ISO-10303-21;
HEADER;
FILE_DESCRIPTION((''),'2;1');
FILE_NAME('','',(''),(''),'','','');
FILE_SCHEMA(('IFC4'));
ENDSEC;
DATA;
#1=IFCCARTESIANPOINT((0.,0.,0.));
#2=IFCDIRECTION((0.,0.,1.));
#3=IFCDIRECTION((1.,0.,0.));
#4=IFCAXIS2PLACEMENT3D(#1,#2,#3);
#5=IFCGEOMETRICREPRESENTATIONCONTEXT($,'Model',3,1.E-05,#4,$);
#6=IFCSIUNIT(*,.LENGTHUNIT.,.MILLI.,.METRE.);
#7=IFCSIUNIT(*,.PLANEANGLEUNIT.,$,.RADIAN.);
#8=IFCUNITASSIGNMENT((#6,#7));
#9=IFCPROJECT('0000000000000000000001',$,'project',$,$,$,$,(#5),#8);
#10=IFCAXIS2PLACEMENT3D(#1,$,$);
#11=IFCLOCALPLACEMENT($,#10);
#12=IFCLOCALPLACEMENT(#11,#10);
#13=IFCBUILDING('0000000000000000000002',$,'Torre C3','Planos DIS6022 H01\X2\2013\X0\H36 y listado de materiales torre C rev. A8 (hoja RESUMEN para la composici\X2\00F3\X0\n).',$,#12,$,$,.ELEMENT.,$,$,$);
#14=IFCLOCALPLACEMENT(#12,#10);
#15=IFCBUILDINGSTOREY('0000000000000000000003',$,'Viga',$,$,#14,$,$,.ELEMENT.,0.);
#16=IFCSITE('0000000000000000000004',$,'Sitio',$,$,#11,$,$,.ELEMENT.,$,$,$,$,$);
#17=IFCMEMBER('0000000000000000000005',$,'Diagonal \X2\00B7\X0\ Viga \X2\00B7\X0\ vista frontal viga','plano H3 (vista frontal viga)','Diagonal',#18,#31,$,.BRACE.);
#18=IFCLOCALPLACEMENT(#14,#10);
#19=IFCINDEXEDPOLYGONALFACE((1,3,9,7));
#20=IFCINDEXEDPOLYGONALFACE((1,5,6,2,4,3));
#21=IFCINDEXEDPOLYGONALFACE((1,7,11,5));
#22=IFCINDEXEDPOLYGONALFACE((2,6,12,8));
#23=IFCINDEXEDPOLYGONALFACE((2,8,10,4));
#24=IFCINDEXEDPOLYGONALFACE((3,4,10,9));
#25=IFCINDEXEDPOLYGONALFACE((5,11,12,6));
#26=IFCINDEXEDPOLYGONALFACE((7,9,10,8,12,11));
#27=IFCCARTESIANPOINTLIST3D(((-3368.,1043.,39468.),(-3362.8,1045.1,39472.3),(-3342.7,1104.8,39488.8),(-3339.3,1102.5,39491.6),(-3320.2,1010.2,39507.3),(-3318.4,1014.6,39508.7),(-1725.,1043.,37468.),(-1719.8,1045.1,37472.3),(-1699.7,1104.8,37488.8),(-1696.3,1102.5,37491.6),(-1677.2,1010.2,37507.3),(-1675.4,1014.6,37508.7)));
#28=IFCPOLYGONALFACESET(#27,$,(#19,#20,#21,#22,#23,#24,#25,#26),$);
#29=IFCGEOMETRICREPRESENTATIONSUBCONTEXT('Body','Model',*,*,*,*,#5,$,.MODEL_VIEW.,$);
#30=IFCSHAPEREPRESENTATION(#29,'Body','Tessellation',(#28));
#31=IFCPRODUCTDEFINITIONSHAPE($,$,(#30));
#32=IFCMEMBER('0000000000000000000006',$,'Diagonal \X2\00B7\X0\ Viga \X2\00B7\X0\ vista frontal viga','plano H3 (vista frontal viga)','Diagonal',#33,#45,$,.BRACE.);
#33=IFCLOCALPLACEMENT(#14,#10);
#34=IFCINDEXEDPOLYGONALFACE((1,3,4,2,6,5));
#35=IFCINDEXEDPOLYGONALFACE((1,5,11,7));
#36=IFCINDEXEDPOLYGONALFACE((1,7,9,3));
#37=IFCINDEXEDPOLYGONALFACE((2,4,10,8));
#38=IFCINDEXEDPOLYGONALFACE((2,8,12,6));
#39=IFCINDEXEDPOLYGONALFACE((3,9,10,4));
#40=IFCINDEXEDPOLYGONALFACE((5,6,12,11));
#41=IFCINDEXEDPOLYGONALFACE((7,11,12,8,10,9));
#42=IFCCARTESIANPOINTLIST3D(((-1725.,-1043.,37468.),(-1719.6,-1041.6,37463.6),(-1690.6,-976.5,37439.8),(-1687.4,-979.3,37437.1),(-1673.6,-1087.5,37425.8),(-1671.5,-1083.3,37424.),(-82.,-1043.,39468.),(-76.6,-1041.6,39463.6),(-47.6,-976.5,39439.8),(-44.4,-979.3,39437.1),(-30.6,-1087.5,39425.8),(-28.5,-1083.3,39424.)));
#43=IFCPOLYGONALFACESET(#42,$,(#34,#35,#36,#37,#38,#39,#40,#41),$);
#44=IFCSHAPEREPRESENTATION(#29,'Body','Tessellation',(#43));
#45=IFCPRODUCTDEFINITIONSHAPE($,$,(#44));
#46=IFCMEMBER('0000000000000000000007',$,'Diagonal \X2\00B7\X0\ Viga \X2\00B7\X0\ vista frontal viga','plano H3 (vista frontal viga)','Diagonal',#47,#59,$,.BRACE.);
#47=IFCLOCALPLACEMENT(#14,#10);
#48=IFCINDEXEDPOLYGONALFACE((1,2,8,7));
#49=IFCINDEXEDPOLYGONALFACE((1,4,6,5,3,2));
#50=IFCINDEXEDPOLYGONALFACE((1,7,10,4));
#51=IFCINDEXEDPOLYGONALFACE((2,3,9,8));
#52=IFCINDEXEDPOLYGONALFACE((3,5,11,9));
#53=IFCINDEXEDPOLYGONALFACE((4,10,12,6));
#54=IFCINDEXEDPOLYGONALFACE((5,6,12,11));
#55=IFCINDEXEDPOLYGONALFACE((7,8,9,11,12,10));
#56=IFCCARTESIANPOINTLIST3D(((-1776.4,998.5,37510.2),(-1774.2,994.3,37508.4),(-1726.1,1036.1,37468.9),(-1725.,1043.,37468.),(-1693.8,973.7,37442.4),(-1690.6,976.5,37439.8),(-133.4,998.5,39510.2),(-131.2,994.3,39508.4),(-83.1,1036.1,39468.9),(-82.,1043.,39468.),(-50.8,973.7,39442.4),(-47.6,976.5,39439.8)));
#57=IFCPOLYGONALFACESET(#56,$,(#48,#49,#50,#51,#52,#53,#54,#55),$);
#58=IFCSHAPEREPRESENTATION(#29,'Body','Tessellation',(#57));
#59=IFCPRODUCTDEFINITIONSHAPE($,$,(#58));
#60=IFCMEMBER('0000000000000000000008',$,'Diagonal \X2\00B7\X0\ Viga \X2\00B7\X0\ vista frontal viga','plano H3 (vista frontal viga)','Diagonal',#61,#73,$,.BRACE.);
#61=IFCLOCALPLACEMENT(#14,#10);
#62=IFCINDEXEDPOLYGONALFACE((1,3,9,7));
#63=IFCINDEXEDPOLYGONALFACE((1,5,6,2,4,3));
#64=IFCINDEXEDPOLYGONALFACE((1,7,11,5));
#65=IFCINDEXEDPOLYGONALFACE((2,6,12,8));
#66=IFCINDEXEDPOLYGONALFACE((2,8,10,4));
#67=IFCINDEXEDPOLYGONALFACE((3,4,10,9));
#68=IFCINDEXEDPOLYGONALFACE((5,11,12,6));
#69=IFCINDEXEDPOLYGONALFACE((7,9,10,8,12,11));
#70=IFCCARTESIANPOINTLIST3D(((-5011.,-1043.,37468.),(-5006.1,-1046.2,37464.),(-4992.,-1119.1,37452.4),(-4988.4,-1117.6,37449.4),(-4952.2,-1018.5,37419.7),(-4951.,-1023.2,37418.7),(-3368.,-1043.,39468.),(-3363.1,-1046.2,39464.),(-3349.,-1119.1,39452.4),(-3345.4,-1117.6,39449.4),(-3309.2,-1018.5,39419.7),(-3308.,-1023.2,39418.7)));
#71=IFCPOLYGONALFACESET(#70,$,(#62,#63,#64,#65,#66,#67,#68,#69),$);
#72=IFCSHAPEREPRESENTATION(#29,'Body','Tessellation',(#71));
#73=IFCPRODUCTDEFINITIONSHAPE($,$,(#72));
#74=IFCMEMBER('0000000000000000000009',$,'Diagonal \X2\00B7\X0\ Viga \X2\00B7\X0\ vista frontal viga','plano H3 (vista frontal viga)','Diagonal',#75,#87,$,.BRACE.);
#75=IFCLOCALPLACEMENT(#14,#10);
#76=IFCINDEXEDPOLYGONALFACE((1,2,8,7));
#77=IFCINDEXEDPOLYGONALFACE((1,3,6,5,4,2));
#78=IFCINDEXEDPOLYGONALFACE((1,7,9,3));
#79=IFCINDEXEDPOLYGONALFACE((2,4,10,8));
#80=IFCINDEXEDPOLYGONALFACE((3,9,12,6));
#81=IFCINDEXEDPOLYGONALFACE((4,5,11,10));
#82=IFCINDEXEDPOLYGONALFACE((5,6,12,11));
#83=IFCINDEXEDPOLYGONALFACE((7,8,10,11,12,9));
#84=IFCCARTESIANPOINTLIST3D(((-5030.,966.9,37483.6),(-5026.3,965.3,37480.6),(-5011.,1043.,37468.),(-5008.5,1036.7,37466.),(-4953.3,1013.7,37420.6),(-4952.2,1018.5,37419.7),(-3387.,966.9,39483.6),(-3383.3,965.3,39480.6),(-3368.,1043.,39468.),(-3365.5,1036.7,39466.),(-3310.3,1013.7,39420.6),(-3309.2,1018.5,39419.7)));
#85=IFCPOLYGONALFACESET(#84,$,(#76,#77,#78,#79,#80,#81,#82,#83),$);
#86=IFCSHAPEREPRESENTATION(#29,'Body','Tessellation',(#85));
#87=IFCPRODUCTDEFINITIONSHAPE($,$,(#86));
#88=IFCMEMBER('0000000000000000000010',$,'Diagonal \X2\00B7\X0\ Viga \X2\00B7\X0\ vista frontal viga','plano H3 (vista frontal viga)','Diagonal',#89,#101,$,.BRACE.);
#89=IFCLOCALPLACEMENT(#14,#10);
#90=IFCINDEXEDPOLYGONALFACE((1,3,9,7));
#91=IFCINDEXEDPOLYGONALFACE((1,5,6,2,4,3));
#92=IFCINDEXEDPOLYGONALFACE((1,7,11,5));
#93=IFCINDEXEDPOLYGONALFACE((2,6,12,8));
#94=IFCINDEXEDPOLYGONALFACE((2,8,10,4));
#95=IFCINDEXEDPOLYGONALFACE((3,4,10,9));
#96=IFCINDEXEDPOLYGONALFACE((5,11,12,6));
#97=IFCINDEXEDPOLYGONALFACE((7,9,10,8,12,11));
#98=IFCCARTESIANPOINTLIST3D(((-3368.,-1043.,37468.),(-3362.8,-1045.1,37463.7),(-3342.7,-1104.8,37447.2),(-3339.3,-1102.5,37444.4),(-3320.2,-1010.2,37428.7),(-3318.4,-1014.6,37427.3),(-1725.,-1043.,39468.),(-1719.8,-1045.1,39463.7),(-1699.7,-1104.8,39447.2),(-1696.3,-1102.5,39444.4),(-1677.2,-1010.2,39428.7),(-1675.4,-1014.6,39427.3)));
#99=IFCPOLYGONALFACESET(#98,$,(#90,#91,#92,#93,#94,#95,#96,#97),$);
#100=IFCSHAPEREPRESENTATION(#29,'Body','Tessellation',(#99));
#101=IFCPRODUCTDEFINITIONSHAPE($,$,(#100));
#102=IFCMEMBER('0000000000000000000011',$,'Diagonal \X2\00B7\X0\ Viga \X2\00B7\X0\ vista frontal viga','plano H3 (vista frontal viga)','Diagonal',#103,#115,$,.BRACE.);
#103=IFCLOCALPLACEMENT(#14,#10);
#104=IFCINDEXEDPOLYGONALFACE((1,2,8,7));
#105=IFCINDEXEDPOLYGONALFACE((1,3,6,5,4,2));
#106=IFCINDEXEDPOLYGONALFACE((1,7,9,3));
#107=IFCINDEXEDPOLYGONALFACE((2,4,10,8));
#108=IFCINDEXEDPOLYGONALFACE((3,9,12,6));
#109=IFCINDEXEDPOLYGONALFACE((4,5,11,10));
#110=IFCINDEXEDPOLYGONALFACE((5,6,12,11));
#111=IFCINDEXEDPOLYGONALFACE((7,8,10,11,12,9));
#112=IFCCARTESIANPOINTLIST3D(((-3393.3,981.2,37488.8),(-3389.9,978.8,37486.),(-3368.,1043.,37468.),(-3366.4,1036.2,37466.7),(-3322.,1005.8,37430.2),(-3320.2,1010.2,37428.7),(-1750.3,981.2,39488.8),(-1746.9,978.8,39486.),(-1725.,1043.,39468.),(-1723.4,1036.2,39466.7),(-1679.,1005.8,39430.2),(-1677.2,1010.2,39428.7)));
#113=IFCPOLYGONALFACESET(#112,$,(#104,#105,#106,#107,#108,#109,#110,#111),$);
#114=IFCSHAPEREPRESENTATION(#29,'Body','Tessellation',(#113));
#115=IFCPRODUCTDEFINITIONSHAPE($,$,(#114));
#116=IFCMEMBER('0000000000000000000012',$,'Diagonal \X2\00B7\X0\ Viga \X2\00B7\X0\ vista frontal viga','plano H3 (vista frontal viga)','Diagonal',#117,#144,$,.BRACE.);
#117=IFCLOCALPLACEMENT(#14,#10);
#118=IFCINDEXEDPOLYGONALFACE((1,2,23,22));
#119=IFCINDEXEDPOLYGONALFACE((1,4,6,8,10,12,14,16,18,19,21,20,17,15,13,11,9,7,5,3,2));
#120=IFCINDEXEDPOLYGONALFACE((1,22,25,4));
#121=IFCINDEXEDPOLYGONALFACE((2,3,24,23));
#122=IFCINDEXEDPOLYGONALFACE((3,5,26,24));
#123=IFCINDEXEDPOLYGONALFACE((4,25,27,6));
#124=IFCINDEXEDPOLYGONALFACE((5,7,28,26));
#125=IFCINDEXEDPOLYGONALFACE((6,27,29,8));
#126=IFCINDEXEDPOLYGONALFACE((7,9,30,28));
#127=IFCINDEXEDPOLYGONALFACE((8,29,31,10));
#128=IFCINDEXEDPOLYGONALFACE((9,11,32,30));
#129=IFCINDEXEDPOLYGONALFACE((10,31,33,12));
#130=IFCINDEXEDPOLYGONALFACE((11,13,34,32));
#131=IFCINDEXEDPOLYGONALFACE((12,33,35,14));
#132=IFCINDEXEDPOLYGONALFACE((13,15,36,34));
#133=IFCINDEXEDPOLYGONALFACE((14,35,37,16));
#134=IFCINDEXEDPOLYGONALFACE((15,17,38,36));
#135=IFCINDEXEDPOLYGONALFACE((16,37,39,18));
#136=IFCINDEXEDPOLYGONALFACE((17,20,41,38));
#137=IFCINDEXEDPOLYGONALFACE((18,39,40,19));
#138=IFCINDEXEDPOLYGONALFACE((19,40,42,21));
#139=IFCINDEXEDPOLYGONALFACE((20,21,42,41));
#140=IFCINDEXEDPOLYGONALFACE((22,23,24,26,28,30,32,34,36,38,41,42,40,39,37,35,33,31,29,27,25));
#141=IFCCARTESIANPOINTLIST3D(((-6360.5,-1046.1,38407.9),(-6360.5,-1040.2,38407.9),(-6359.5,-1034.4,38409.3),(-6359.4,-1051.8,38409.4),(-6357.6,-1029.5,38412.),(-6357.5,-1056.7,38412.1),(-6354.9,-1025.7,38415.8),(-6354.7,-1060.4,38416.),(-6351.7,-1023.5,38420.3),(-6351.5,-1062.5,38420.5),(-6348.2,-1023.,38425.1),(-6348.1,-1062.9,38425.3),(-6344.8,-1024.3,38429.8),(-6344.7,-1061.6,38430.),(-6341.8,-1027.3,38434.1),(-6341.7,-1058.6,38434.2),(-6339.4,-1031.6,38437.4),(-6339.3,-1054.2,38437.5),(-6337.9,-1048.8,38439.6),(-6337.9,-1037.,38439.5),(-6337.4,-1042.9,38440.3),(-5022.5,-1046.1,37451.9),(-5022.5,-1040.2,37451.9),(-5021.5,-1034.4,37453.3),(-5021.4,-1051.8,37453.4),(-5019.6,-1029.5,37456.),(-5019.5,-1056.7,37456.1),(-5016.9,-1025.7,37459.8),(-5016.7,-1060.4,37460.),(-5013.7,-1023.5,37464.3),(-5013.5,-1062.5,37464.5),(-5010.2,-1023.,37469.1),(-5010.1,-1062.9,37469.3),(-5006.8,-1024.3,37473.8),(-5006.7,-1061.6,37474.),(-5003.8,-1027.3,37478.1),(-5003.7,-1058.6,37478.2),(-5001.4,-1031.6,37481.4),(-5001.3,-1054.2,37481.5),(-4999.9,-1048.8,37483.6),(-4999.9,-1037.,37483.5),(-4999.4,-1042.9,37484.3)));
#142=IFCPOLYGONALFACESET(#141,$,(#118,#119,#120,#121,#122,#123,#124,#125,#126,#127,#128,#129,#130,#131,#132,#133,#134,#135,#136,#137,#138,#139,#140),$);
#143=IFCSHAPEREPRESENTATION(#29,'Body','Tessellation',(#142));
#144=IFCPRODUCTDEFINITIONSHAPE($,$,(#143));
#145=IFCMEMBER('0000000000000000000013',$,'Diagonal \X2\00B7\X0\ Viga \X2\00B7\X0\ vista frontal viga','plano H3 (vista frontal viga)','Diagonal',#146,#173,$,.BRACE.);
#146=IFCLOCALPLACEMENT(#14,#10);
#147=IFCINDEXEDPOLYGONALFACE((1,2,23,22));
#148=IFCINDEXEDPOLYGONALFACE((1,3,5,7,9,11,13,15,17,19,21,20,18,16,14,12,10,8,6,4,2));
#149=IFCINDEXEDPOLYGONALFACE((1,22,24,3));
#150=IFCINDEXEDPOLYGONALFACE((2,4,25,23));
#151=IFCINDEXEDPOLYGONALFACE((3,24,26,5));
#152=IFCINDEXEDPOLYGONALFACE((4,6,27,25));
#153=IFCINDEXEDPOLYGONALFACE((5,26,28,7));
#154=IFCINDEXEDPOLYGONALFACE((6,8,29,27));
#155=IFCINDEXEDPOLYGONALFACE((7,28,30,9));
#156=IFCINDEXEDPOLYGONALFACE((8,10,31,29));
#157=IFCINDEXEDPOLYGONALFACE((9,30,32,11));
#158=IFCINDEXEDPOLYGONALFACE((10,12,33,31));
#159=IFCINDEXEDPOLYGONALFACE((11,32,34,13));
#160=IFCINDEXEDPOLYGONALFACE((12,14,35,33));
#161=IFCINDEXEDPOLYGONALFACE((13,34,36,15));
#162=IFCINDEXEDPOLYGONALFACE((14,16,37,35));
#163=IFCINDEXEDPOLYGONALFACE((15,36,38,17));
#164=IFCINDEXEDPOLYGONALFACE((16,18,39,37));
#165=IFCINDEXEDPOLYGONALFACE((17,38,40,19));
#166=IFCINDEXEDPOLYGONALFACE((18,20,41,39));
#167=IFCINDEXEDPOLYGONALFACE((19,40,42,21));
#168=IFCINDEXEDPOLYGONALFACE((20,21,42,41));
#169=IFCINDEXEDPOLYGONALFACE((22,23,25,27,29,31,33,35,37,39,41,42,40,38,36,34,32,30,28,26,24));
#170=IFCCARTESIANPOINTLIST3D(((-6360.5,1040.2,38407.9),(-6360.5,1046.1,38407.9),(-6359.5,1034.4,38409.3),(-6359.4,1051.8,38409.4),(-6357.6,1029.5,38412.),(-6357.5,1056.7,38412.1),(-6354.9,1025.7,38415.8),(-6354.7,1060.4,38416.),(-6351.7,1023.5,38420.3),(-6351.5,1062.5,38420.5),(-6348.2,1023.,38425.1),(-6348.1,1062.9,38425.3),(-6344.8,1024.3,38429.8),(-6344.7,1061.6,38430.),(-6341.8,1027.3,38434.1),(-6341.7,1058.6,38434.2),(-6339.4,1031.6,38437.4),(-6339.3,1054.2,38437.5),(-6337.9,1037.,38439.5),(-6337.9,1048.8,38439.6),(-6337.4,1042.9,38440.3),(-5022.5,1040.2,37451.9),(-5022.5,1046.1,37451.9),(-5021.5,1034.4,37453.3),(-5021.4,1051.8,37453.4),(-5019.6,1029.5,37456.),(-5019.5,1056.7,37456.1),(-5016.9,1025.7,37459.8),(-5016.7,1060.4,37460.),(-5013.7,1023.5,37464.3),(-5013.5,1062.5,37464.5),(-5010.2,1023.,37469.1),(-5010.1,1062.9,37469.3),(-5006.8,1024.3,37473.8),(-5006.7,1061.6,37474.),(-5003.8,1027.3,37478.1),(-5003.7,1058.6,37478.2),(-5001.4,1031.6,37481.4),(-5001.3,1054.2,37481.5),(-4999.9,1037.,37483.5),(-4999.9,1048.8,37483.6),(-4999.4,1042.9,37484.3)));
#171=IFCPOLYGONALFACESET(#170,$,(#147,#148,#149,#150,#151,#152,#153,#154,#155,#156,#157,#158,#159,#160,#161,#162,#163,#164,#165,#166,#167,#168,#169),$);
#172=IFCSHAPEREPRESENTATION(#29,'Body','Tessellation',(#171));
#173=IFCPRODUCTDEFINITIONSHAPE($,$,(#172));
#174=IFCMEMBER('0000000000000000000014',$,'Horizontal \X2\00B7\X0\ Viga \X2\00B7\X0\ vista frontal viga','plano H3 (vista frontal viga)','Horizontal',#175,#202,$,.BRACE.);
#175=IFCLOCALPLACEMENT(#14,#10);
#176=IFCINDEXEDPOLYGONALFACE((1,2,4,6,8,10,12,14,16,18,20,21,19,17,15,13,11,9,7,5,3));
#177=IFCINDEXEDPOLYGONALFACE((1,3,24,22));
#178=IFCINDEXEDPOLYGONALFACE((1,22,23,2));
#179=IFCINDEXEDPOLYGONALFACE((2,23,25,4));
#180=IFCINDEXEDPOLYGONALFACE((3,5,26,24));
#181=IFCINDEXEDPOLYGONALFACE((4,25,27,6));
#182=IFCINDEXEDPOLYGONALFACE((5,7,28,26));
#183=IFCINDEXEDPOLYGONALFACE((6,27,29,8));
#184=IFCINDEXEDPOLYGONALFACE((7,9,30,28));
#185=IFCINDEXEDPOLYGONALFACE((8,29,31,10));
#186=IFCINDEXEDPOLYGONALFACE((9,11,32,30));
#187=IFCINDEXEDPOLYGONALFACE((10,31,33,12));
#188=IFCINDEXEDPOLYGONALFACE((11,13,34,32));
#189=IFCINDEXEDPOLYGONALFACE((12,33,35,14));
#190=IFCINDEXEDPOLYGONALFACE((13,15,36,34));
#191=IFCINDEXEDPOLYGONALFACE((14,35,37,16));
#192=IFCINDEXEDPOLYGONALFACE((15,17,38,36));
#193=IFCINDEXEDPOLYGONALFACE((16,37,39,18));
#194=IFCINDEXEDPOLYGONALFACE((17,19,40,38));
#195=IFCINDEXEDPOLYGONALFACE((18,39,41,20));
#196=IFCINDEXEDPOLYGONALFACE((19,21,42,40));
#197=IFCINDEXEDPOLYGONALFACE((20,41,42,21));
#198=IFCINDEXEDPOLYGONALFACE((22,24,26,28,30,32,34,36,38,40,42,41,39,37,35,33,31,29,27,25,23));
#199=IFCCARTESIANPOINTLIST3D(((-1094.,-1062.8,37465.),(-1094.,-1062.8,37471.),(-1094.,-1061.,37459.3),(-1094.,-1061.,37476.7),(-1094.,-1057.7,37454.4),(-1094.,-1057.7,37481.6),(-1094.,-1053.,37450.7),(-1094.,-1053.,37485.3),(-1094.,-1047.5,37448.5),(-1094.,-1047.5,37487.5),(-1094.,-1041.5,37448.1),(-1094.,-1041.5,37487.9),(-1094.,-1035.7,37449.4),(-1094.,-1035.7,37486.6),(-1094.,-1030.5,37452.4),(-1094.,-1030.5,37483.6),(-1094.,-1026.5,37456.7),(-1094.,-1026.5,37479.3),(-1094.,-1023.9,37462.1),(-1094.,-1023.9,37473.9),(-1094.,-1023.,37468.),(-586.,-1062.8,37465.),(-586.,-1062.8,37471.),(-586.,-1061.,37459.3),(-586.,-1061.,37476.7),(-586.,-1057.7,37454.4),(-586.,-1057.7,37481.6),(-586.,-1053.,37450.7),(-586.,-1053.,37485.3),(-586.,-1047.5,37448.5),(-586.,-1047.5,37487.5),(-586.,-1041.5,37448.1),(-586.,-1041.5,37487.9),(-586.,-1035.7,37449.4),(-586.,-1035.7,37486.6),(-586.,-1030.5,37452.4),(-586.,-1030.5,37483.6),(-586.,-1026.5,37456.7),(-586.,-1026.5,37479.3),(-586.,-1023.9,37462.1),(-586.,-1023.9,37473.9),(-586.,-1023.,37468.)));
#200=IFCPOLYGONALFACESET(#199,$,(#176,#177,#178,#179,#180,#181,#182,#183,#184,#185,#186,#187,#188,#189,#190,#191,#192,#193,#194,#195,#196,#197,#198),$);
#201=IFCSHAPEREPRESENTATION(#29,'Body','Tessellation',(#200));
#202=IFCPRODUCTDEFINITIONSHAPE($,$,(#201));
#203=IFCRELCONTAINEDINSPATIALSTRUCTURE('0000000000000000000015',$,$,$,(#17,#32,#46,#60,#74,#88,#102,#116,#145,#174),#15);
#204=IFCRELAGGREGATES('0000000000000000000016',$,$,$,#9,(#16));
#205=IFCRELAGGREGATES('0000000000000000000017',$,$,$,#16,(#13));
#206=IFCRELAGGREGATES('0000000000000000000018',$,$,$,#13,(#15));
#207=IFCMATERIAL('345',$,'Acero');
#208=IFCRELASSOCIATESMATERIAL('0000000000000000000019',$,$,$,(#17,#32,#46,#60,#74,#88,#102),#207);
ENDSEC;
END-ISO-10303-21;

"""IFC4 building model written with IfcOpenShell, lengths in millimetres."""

from ifc_helpers import new_model, si_unit, frame, frame_2d, origin, origin_with_axes, place, context, subcontext, project, spatial, circle, l_section, extrude, material, element, save


model = new_model("IFC4")

# Units and contexts
model_context = context("Model", 3, precision=1e-05, world=origin_with_axes())
body_context = subcontext(model_context, "Body", "Model", "MODEL_VIEW")
ifc_project = project(units=[si_unit("LENGTHUNIT", "METRE", prefix="MILLI"), si_unit("PLANEANGLEUNIT", "RADIAN")], contexts=[model_context])

# Site, building, storey
site_placement = place(None, origin())
site = spatial("IfcSite", under=ifc_project, at=site_placement, Name="Sitio", CompositionType="ELEMENT")
building_placement = place(site_placement, origin())
building = spatial("IfcBuilding", under=site, at=building_placement, Name="Torre C3", Description="Planos DIS6022 H01–H36 y listado de materiales torre C rev. A8 (hoja RESUMEN para la composición).", CompositionType="ELEMENT")
storey_placement = place(building_placement, origin())
storey = spatial("IfcBuildingStorey", under=building, at=storey_placement, Name="Viga", CompositionType="ELEMENT", Elevation=0.0)

# Members
ifc_material_1 = material(Name="345", Category="Acero")
for number, where, z_axis, x_axis, name in (
    (1, (-1725.0, 1043.0, 37468.0), (-0.634772, 0.0, 0.772699), (0.682717, -0.468339, 0.560852), "Diagonal · Viga · vista frontal viga"),
):
    element("IfcMember", number, at=place(storey_placement, frame(where, z_axis=z_axis, x_axis=x_axis)), inside=storey, material=ifc_material_1, Name=name, Description="plano H3 (vista frontal viga)", ObjectType="Diagonal", PredefinedType="BRACE", context=body_context, shape_type="SweptSolid", body=[
        extrude(l_section(Depth=70.0, Width=70.0, Thickness=5.0, at=frame_2d((35.0, 35.0))), None, (0.0, 0.0, 1.0), 2588.3),
    ])
for number, where, z_axis, x_axis, name in (
    (2, (-82.0, -1043.0, 39468.0), (-0.634772, 0.0, -0.772699), (0.429809, 0.831019, -0.353088), "Diagonal · Viga · vista frontal viga"),
    (3, (-82.0, 1043.0, 39468.0), (-0.634772, 0.0, -0.772699), (0.429809, -0.831019, -0.353088), "Diagonal · Viga · vista frontal viga"),
    (4, (-3368.0, -1043.0, 39468.0), (-0.634772, 0.0, -0.772699), (0.735468, 0.306666, -0.604187), "Diagonal · Viga · vista frontal viga"),
    (5, (-3368.0, 1043.0, 39468.0), (-0.634772, 0.0, -0.772699), (0.735468, -0.306666, -0.604187), "Diagonal · Viga · vista frontal viga"),
):
    element("IfcMember", number, at=place(storey_placement, frame(where, z_axis=z_axis, x_axis=x_axis)), inside=storey, material=ifc_material_1, Name=name, Description="plano H3 (vista frontal viga)", ObjectType="Diagonal", PredefinedType="BRACE", context=body_context, shape_type="SweptSolid", body=[
        extrude(l_section(Depth=80.0, Width=80.0, Thickness=5.0, at=frame_2d((40.0, 40.0))), None, (0.0, 0.0, 1.0), 2588.3),
    ])
for number, where, z_axis, x_axis, name in (
    (6, (-1725.0, -1043.0, 39468.0), (-0.634772, 0.0, -0.772699), (0.682717, 0.468339, -0.560852), "Diagonal · Viga · vista frontal viga"),
    (7, (-1725.0, 1043.0, 39468.0), (-0.634772, 0.0, -0.772699), (0.682717, -0.468339, -0.560852), "Diagonal · Viga · vista frontal viga"),
):
    element("IfcMember", number, at=place(storey_placement, frame(where, z_axis=z_axis, x_axis=x_axis)), inside=storey, material=ifc_material_1, Name=name, Description="plano H3 (vista frontal viga)", ObjectType="Diagonal", PredefinedType="BRACE", context=body_context, shape_type="SweptSolid", body=[
        extrude(l_section(Depth=70.0, Width=70.0, Thickness=5.0, at=frame_2d((35.0, 35.0))), None, (0.0, 0.0, 1.0), 2588.3),
    ])
for number, where, z_axis, x_axis, name in (
    (8, (-5011.0, -1043.0, 37468.0), (-0.813651, 0.0, 0.581353), (0.554357, 0.301193, 0.775868), "Diagonal · Viga · vista frontal viga"),
    (9, (-5011.0, 1043.0, 37468.0), (-0.813651, 0.0, 0.581353), (0.554357, -0.301193, 0.775868), "Diagonal · Viga · vista frontal viga"),
):
    element("IfcMember", number, at=place(storey_placement, frame(where, z_axis=z_axis, x_axis=x_axis)), inside=storey, Name=name, Description="plano H3 (vista frontal viga)", ObjectType="Diagonal", PredefinedType="BRACE", context=body_context, shape_type="SweptSolid", body=[
        extrude(circle(Radius=20.0), None, (0.0, 0.0, 1.0), 1644.4),
    ])
for number, where, z_axis, x_axis, name in (
    (10, (-1094.0, -1043.0, 37468.0), (1.0, 0.0, 0.0), (0.0, 1.0, 0.0), "Horizontal · Viga · vista frontal viga"),
):
    element("IfcMember", number, at=place(storey_placement, frame(where, z_axis=z_axis, x_axis=x_axis)), inside=storey, Name=name, Description="plano H3 (vista frontal viga)", ObjectType="Horizontal", PredefinedType="BRACE", context=body_context, shape_type="SweptSolid", body=[
        extrude(circle(Radius=20.0), None, (0.0, 0.0, 1.0), 508.0),
    ])

save(model, "model.ifc")
